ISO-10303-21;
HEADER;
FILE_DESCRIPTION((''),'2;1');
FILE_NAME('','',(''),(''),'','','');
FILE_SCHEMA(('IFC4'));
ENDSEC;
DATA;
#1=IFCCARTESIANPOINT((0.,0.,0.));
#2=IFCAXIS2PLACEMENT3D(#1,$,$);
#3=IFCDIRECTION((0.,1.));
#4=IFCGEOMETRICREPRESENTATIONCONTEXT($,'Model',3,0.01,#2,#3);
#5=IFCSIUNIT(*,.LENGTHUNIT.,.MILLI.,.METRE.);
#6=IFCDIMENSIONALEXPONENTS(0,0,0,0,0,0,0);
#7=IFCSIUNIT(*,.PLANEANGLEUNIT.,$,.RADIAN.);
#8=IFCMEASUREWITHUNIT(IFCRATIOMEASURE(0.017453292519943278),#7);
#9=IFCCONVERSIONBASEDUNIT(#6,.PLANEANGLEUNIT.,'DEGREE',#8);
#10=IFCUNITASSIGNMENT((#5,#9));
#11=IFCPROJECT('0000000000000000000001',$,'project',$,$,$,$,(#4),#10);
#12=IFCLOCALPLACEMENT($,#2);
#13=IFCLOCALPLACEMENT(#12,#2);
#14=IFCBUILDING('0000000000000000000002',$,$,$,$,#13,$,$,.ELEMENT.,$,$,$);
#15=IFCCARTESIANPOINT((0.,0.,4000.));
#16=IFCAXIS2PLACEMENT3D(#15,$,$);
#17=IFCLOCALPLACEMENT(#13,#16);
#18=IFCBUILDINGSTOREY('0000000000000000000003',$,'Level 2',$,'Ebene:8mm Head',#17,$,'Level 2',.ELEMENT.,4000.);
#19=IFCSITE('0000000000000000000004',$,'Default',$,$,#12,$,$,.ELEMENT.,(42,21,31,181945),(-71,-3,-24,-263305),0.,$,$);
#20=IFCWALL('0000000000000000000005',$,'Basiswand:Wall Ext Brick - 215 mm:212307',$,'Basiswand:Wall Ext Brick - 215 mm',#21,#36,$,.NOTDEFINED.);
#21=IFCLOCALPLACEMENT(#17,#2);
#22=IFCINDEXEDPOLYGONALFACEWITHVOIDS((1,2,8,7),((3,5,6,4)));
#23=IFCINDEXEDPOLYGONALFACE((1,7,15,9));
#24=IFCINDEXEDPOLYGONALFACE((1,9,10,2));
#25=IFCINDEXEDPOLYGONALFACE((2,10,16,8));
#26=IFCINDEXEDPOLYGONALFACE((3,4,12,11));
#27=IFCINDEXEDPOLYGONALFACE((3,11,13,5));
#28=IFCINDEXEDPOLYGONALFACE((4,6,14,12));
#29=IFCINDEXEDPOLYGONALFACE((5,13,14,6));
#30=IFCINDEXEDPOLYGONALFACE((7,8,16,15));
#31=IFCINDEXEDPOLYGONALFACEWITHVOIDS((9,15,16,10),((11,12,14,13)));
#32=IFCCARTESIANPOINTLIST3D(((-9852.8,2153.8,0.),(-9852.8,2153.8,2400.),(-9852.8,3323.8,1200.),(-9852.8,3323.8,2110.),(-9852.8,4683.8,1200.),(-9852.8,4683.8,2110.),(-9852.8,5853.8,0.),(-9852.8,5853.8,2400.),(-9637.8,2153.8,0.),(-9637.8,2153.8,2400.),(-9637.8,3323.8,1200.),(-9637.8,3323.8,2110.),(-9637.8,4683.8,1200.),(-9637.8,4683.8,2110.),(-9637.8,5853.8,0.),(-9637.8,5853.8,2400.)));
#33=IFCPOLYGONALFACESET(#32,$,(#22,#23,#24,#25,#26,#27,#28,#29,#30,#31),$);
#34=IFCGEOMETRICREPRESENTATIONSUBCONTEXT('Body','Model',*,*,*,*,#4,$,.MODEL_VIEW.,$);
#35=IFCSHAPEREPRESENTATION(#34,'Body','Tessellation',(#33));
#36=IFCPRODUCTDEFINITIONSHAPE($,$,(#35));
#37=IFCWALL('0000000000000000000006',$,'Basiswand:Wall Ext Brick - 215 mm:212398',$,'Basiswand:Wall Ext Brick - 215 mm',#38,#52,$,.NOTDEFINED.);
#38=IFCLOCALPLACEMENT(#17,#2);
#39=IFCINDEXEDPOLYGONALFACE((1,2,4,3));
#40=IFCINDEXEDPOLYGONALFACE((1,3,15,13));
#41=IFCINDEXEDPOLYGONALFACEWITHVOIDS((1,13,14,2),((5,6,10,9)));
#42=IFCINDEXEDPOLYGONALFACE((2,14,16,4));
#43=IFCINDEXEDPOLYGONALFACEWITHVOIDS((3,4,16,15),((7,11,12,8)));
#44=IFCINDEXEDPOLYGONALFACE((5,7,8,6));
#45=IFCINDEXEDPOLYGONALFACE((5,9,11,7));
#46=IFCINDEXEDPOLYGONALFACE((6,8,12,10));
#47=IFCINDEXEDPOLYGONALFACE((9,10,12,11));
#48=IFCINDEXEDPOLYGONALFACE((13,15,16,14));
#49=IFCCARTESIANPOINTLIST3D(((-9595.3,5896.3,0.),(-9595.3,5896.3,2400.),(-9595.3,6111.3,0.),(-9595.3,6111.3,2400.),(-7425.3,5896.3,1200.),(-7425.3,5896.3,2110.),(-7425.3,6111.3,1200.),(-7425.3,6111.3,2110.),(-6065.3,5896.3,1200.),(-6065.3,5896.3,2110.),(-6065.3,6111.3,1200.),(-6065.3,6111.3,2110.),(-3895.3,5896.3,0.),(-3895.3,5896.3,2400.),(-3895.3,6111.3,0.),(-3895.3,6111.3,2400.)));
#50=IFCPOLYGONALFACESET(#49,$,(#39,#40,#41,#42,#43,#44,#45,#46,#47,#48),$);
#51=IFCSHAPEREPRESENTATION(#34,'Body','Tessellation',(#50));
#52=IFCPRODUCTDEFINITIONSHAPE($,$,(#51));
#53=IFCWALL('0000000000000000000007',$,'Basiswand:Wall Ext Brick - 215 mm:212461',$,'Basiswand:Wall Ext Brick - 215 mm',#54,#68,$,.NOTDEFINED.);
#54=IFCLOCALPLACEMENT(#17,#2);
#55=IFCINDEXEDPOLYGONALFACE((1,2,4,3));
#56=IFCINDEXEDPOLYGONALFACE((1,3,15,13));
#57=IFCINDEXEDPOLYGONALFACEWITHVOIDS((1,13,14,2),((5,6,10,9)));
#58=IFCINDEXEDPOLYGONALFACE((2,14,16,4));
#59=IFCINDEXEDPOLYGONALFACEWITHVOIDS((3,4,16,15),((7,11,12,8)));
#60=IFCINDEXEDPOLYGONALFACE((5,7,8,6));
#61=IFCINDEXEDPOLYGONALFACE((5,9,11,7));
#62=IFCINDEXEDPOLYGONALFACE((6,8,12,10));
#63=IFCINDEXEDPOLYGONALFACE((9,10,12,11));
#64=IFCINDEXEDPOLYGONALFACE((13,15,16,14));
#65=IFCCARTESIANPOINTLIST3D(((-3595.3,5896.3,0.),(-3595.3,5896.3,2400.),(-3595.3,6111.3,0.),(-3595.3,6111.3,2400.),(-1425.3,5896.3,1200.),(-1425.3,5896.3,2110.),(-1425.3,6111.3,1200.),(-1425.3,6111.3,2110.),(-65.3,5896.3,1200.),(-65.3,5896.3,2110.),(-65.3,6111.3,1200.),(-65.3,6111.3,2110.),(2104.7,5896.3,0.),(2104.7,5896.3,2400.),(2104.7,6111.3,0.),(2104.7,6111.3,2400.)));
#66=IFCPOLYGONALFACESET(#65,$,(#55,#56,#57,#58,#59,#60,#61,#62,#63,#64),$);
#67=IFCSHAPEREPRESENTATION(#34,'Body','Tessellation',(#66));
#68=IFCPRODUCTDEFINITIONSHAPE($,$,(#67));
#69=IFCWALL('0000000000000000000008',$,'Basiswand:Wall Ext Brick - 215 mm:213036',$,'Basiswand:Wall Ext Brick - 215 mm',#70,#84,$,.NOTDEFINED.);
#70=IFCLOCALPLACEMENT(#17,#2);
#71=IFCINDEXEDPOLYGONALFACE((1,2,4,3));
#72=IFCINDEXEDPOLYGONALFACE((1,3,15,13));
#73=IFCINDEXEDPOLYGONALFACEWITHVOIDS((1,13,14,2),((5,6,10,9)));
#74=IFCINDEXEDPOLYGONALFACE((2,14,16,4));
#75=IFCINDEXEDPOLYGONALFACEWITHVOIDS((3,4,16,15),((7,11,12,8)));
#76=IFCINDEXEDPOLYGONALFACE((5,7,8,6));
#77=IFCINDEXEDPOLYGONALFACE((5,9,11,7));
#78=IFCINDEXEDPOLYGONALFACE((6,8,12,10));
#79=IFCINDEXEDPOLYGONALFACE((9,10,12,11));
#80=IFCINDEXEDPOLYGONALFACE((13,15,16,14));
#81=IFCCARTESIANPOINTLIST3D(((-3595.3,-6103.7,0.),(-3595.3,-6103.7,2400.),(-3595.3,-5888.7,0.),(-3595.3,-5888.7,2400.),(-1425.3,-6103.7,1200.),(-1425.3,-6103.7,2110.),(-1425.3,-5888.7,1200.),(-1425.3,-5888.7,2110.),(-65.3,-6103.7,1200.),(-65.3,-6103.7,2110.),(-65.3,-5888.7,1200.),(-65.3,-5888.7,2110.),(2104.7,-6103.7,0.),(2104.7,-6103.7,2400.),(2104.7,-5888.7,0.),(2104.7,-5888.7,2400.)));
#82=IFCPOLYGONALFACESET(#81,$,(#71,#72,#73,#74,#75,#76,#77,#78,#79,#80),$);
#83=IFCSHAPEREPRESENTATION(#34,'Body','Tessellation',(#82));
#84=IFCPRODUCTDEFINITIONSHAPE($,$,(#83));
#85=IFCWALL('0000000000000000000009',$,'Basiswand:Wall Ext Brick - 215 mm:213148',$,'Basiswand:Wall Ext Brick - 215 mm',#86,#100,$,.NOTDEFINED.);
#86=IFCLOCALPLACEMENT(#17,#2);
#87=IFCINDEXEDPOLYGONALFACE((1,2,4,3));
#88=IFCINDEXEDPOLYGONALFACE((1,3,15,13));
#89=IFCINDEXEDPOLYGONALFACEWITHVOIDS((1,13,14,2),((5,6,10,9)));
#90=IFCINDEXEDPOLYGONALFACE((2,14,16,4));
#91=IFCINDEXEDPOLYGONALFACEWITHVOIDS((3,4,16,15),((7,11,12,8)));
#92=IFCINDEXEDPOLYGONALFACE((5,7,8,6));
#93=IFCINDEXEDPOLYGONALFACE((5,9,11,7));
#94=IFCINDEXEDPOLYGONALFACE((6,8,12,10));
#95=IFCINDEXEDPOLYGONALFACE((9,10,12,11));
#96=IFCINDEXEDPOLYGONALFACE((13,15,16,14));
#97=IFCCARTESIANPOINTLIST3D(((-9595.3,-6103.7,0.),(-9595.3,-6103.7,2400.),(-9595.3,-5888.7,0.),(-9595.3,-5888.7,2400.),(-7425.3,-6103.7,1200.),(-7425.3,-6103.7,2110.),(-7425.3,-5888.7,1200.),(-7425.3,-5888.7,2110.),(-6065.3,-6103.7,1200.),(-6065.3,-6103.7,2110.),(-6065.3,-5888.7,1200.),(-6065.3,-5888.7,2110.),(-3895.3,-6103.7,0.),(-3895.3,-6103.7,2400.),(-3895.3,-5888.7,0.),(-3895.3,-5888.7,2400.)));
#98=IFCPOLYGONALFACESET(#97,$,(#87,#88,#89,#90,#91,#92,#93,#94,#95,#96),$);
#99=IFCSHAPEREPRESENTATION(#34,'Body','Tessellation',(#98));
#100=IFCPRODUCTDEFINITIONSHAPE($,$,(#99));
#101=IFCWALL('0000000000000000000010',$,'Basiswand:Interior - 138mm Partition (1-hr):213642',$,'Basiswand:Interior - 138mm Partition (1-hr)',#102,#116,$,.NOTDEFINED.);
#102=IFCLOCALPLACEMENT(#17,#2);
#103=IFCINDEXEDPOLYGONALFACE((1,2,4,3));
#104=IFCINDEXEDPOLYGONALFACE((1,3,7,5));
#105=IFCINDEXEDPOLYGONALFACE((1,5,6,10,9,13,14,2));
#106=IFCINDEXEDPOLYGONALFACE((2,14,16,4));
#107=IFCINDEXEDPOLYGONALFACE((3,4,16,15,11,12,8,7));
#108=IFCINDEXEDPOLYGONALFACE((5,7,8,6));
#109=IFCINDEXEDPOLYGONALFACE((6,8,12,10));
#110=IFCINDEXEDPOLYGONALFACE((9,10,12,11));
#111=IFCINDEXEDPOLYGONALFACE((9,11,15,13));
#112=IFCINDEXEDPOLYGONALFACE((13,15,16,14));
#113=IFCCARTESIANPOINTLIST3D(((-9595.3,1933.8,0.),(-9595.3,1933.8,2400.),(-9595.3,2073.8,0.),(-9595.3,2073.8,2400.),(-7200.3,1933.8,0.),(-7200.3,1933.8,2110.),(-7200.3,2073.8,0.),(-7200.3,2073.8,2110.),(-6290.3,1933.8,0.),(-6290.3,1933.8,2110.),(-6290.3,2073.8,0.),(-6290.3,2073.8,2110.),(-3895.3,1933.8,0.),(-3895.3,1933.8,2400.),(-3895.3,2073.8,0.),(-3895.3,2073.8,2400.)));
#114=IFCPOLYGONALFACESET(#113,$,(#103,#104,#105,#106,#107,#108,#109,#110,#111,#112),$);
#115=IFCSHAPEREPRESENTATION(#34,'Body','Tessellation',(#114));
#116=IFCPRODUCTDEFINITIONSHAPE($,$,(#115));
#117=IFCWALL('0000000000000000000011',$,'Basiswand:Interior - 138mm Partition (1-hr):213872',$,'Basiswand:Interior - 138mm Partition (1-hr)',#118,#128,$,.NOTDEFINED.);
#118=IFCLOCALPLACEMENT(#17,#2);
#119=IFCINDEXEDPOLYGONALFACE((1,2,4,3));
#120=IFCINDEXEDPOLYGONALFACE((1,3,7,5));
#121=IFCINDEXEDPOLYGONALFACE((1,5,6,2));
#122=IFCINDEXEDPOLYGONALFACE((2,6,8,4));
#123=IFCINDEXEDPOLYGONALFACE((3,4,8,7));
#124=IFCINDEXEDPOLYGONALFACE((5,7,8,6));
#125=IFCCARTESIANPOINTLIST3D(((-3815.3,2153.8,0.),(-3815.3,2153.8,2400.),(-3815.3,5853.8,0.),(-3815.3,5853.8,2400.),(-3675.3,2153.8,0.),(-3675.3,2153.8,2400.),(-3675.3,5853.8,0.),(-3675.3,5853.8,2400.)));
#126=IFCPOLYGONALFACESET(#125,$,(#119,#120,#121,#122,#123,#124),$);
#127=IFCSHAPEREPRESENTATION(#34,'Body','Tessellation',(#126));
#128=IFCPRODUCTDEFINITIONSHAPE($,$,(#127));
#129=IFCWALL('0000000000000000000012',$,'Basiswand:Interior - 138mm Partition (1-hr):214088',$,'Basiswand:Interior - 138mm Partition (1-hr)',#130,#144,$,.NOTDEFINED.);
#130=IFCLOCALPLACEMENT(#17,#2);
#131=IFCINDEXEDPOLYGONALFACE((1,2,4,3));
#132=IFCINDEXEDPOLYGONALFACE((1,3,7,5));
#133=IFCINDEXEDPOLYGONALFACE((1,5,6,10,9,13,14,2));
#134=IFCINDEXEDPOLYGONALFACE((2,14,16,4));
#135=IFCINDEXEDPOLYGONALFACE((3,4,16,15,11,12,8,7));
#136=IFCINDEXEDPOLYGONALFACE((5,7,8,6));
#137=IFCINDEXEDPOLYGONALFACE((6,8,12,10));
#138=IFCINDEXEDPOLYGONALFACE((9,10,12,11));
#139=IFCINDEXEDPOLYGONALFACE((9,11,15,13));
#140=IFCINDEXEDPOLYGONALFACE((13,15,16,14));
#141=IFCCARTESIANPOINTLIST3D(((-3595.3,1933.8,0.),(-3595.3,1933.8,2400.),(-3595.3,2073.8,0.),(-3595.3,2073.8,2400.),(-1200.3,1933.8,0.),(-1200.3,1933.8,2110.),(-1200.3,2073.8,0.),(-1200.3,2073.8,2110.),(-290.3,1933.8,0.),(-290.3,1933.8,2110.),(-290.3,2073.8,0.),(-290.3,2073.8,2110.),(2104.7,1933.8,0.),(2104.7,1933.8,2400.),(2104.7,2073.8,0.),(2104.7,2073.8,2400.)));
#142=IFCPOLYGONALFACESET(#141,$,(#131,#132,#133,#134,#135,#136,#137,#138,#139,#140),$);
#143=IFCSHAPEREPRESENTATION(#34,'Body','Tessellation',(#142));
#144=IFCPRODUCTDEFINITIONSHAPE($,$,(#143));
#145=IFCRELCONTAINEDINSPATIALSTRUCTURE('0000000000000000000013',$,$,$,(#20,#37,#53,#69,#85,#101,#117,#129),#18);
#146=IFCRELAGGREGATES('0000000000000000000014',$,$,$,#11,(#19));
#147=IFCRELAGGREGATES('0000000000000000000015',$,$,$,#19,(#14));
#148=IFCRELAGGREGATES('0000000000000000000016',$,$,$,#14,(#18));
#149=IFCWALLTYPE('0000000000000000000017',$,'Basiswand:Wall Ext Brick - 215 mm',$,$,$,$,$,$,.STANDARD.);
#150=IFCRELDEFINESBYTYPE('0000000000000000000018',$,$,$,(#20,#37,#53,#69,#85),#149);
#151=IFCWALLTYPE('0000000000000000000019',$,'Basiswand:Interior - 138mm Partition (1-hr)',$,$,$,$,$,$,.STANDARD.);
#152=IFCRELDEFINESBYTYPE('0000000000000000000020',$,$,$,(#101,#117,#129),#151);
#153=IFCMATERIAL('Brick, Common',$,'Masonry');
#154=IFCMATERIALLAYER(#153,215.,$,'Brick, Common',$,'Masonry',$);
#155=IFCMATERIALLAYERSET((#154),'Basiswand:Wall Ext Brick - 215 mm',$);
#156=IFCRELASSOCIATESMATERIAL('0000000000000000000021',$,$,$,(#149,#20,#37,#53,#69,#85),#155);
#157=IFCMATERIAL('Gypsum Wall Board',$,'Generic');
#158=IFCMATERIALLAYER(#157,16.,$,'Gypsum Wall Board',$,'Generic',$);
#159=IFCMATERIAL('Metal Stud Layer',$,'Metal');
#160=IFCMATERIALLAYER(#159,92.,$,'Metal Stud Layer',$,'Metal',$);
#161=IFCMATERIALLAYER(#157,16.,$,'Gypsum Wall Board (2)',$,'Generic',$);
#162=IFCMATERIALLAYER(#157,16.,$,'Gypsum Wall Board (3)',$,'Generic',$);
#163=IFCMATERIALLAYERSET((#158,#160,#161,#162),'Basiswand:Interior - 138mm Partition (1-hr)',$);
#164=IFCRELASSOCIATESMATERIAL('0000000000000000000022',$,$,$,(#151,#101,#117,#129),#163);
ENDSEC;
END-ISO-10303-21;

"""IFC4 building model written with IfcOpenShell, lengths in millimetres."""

from ifc_helpers import new_model, entity, si_unit, converted_unit, direction, frame, frame_2d, origin, place, context, subcontext, project, spatial, rectangle, extrude, material, layer, layer_set, layer_usage, type_object, element, save


model = new_model("IFC4")

# Units and contexts
model_context = context("Model", 3, precision=0.01, world=origin(), true_north=direction((0.0, 1.0)))
body_context = subcontext(model_context, "Body", "Model", "MODEL_VIEW")
ifc_project = project(units=[si_unit("LENGTHUNIT", "METRE", prefix="MILLI"), converted_unit("PLANEANGLEUNIT", "DEGREE", entity("IfcRatioMeasure", 0.017453292519943278), si_unit("PLANEANGLEUNIT", "RADIAN"), dimensions=[0, 0, 0, 0, 0, 0, 0])], contexts=[model_context])

# Site, building, storey
site_placement = place(None, origin())
site = spatial("IfcSite", under=ifc_project, at=site_placement, Name="Default", CompositionType="ELEMENT", RefLatitude=(42, 21, 31, 181945), RefLongitude=(-71, -3, -24, -263305), RefElevation=0.0)
building_placement = place(site_placement, origin())
building = spatial("IfcBuilding", under=site, at=building_placement, CompositionType="ELEMENT")
storey_placement = place(building_placement, frame((0.0, 0.0, 4000.0)))
storey = spatial("IfcBuildingStorey", under=building, at=storey_placement, Name="Level 2", ObjectType="Ebene:8mm Head", LongName="Level 2", CompositionType="ELEMENT", Elevation=4000.0)

# Walls, openings
ifc_material_1 = material(Name="Brick, Common", Category="Masonry")
ifc_layer_1 = layer(ifc_material_1, 215.0, Name="Brick, Common", Category="Masonry")
ifc_layer_set_1 = layer_set([ifc_layer_1], Name="Basiswand:Wall Ext Brick - 215 mm")
wall_type_1 = type_object("IfcWallType", Name="Basiswand:Wall Ext Brick - 215 mm", PredefinedType="STANDARD", material=ifc_layer_set_1)
ifc_layer_usage_1 = layer_usage(ifc_layer_set_1, "AXIS2", "NEGATIVE", 107.5)
wall_1_placement = place(storey_placement, frame((-9745.3, 2153.8, 0.0), z_axis=(0.0, 0.0, 1.0), x_axis=(0.0, 1.0, 0.0)))
wall_1 = element("IfcWall", 1, at=wall_1_placement, inside=storey, type_object=wall_type_1, material=ifc_layer_usage_1, Name="Basiswand:Wall Ext Brick - 215 mm:212307", ObjectType="Basiswand:Wall Ext Brick - 215 mm", PredefinedType="NOTDEFINED", context=body_context, shape_type="SweptSolid", body=[
    extrude(rectangle(XDim=3700.0, YDim=215.0, at=frame_2d((1850.0, 0.0), x_axis=(-1.0, 0.0))), origin(), (0.0, 0.0, 1.0), 2400.0),
])
opening_1_placement = place(wall_1_placement, frame((2530.0, 107.5, 1200.0)))
element("IfcOpeningElement", 2, at=opening_1_placement, cuts=wall_1, PredefinedType="OPENING", context=body_context, shape_type="SweptSolid", body=[
    extrude(rectangle(XDim=910.0, YDim=1360.0, at=frame_2d((455.0, 680.0), x_axis=(-1.0, 0.0))), frame((0.0, 0.0, 0.0), z_axis=(0.0, -1.0, 0.0), x_axis=(0.0, 0.0, 1.0)), (0.0, 0.0, 1.0), 215.0),
])
ifc_layer_usage_2 = layer_usage(ifc_layer_set_1, "AXIS2", "NEGATIVE", 107.5)
wall_2_placement = place(storey_placement, frame((-9595.3, 6003.8, 0.0)))
wall_2 = element("IfcWall", 3, at=wall_2_placement, inside=storey, type_object=wall_type_1, material=ifc_layer_usage_2, Name="Basiswand:Wall Ext Brick - 215 mm:212398", ObjectType="Basiswand:Wall Ext Brick - 215 mm", PredefinedType="NOTDEFINED", context=body_context, shape_type="SweptSolid", body=[
    extrude(rectangle(XDim=5700.0, YDim=215.0, at=frame_2d((2850.0, 0.0), x_axis=(-1.0, 0.0))), origin(), (0.0, 0.0, 1.0), 2400.0),
])
opening_2_placement = place(wall_2_placement, frame((2170.0, -107.5, 1200.0)))
element("IfcOpeningElement", 4, at=opening_2_placement, cuts=wall_2, PredefinedType="OPENING", context=body_context, shape_type="SweptSolid", body=[
    extrude(rectangle(XDim=910.0, YDim=1360.0, at=frame_2d((455.0, 680.0), x_axis=(-1.0, 0.0))), frame((0.0, 0.0, 0.0), z_axis=(0.0, 1.0, 0.0), x_axis=(0.0, 0.0, 1.0)), (0.0, 0.0, 1.0), 215.0),
])
ifc_layer_usage_3 = layer_usage(ifc_layer_set_1, "AXIS2", "NEGATIVE", 107.5)
wall_3_placement = place(storey_placement, frame((-3595.3, 6003.8, 0.0)))
wall_3 = element("IfcWall", 5, at=wall_3_placement, inside=storey, type_object=wall_type_1, material=ifc_layer_usage_3, Name="Basiswand:Wall Ext Brick - 215 mm:212461", ObjectType="Basiswand:Wall Ext Brick - 215 mm", PredefinedType="NOTDEFINED", context=body_context, shape_type="SweptSolid", body=[
    extrude(rectangle(XDim=5700.0, YDim=215.0, at=frame_2d((2850.0, 0.0), x_axis=(-1.0, 0.0))), origin(), (0.0, 0.0, 1.0), 2400.0),
])
opening_3_placement = place(wall_3_placement, frame((2170.0, -107.5, 1200.0)))
element("IfcOpeningElement", 6, at=opening_3_placement, cuts=wall_3, PredefinedType="OPENING", context=body_context, shape_type="SweptSolid", body=[
    extrude(rectangle(XDim=910.0, YDim=1360.0, at=frame_2d((455.0, 680.0), x_axis=(-1.0, 0.0))), frame((0.0, 0.0, 0.0), z_axis=(0.0, 1.0, 0.0), x_axis=(0.0, 0.0, 1.0)), (0.0, 0.0, 1.0), 215.0),
])
ifc_layer_usage_4 = layer_usage(ifc_layer_set_1, "AXIS2", "NEGATIVE", 107.5)
wall_4_placement = place(storey_placement, frame((-3595.3, -5996.2, 0.0)))
wall_4 = element("IfcWall", 7, at=wall_4_placement, inside=storey, type_object=wall_type_1, material=ifc_layer_usage_4, Name="Basiswand:Wall Ext Brick - 215 mm:213036", ObjectType="Basiswand:Wall Ext Brick - 215 mm", PredefinedType="NOTDEFINED", context=body_context, shape_type="SweptSolid", body=[
    extrude(rectangle(XDim=5700.0, YDim=215.0, at=frame_2d((2850.0, 0.0), x_axis=(-1.0, 0.0))), origin(), (0.0, 0.0, 1.0), 2400.0),
])
opening_4_placement = place(wall_4_placement, frame((3530.0, 107.5, 1200.0)))
element("IfcOpeningElement", 8, at=opening_4_placement, cuts=wall_4, PredefinedType="OPENING", context=body_context, shape_type="SweptSolid", body=[
    extrude(rectangle(XDim=910.0, YDim=1360.0, at=frame_2d((455.0, 680.0), x_axis=(-1.0, 0.0))), frame((0.0, 0.0, 0.0), z_axis=(0.0, -1.0, 0.0), x_axis=(0.0, 0.0, 1.0)), (0.0, 0.0, 1.0), 215.0),
])
ifc_layer_usage_5 = layer_usage(ifc_layer_set_1, "AXIS2", "NEGATIVE", 107.5)
wall_5_placement = place(storey_placement, frame((-9595.3, -5996.2, 0.0)))
wall_5 = element("IfcWall", 9, at=wall_5_placement, inside=storey, type_object=wall_type_1, material=ifc_layer_usage_5, Name="Basiswand:Wall Ext Brick - 215 mm:213148", ObjectType="Basiswand:Wall Ext Brick - 215 mm", PredefinedType="NOTDEFINED", context=body_context, shape_type="SweptSolid", body=[
    extrude(rectangle(XDim=5700.0, YDim=215.0, at=frame_2d((2850.0, 0.0), x_axis=(-1.0, 0.0))), origin(), (0.0, 0.0, 1.0), 2400.0),
])
opening_5_placement = place(wall_5_placement, frame((2170.0, -107.5, 1200.0)))
element("IfcOpeningElement", 10, at=opening_5_placement, cuts=wall_5, PredefinedType="OPENING", context=body_context, shape_type="SweptSolid", body=[
    extrude(rectangle(XDim=910.0, YDim=1360.0, at=frame_2d((455.0, 680.0), x_axis=(-1.0, 0.0))), frame((0.0, 0.0, 0.0), z_axis=(0.0, 1.0, 0.0), x_axis=(0.0, 0.0, 1.0)), (0.0, 0.0, 1.0), 215.0),
])
ifc_material_2 = material(Name="Gypsum Wall Board", Category="Generic")
ifc_layer_2 = layer(ifc_material_2, 16.0, Name="Gypsum Wall Board", Category="Generic")
ifc_material_3 = material(Name="Metal Stud Layer", Category="Metal")
ifc_layer_3 = layer(ifc_material_3, 92.0, Name="Metal Stud Layer", Category="Metal")
ifc_layer_4 = layer(ifc_material_2, 16.0, Name="Gypsum Wall Board (2)", Category="Generic")
ifc_layer_5 = layer(ifc_material_2, 16.0, Name="Gypsum Wall Board (3)", Category="Generic")
ifc_layer_set_2 = layer_set([ifc_layer_2, ifc_layer_3, ifc_layer_4, ifc_layer_5], Name="Basiswand:Interior - 138mm Partition (1-hr)")
ifc_layer_usage_6 = layer_usage(ifc_layer_set_2, "AXIS2", "NEGATIVE", 70.0)
wall_type_2 = type_object("IfcWallType", Name="Basiswand:Interior - 138mm Partition (1-hr)", PredefinedType="STANDARD", material=ifc_layer_set_2)
wall_6_placement = place(storey_placement, frame((-9595.3, 2003.8, 0.0)))
wall_6 = element("IfcWall", 11, at=wall_6_placement, inside=storey, type_object=wall_type_2, material=ifc_layer_usage_6, Name="Basiswand:Interior - 138mm Partition (1-hr):213642", ObjectType="Basiswand:Interior - 138mm Partition (1-hr)", PredefinedType="NOTDEFINED", context=body_context, shape_type="SweptSolid", body=[
    extrude(rectangle(XDim=5700.0, YDim=140.0, at=frame_2d((2850.0, 0.0), x_axis=(1.0, 0.0))), origin(), (0.0, 0.0, 1.0), 2400.0),
])
opening_6_placement = place(wall_6_placement, frame((2395.0, -70.0, 0.0)))
element("IfcOpeningElement", 12, at=opening_6_placement, cuts=wall_6, PredefinedType="OPENING", context=body_context, shape_type="SweptSolid", body=[
    extrude(rectangle(XDim=2110.0, YDim=910.0, at=frame_2d((1055.0, 455.0), x_axis=(1.0, 0.0))), frame((0.0, 0.0, 0.0), z_axis=(0.0, 1.0, 0.0), x_axis=(0.0, 0.0, 1.0)), (0.0, 0.0, 1.0), 140.0),
])

# Wall
ifc_layer_usage_7 = layer_usage(ifc_layer_set_2, "AXIS2", "NEGATIVE", 70.0)
wall_7_placement = place(storey_placement, frame((-3745.3, 2153.8, 0.0), z_axis=(0.0, 0.0, 1.0), x_axis=(0.0, 1.0, 0.0)))
element("IfcWall", 13, at=wall_7_placement, inside=storey, type_object=wall_type_2, material=ifc_layer_usage_7, Name="Basiswand:Interior - 138mm Partition (1-hr):213872", ObjectType="Basiswand:Interior - 138mm Partition (1-hr)", PredefinedType="NOTDEFINED", context=body_context, shape_type="SweptSolid", body=[
    extrude(rectangle(XDim=3700.0, YDim=140.0, at=frame_2d((1850.0, 0.0), x_axis=(-1.0, 0.0))), origin(), (0.0, 0.0, 1.0), 2400.0),
])

# Wall, opening
ifc_layer_usage_8 = layer_usage(ifc_layer_set_2, "AXIS2", "NEGATIVE", 70.0)
wall_8_placement = place(storey_placement, frame((-3595.3, 2003.8, 0.0)))
wall_8 = element("IfcWall", 14, at=wall_8_placement, inside=storey, type_object=wall_type_2, material=ifc_layer_usage_8, Name="Basiswand:Interior - 138mm Partition (1-hr):214088", ObjectType="Basiswand:Interior - 138mm Partition (1-hr)", PredefinedType="NOTDEFINED", context=body_context, shape_type="SweptSolid", body=[
    extrude(rectangle(XDim=5700.0, YDim=140.0, at=frame_2d((2850.0, 0.0), x_axis=(1.0, 0.0))), origin(), (0.0, 0.0, 1.0), 2400.0),
])
opening_7_placement = place(wall_8_placement, frame((2395.0, -70.0, 0.0)))
element("IfcOpeningElement", 15, at=opening_7_placement, cuts=wall_8, PredefinedType="OPENING", context=body_context, shape_type="SweptSolid", body=[
    extrude(rectangle(XDim=2110.0, YDim=910.0, at=frame_2d((1055.0, 455.0), x_axis=(1.0, 0.0))), frame((0.0, 0.0, 0.0), z_axis=(0.0, 1.0, 0.0), x_axis=(0.0, 0.0, 1.0)), (0.0, 0.0, 1.0), 140.0),
])

save(model, "model.ifc")
